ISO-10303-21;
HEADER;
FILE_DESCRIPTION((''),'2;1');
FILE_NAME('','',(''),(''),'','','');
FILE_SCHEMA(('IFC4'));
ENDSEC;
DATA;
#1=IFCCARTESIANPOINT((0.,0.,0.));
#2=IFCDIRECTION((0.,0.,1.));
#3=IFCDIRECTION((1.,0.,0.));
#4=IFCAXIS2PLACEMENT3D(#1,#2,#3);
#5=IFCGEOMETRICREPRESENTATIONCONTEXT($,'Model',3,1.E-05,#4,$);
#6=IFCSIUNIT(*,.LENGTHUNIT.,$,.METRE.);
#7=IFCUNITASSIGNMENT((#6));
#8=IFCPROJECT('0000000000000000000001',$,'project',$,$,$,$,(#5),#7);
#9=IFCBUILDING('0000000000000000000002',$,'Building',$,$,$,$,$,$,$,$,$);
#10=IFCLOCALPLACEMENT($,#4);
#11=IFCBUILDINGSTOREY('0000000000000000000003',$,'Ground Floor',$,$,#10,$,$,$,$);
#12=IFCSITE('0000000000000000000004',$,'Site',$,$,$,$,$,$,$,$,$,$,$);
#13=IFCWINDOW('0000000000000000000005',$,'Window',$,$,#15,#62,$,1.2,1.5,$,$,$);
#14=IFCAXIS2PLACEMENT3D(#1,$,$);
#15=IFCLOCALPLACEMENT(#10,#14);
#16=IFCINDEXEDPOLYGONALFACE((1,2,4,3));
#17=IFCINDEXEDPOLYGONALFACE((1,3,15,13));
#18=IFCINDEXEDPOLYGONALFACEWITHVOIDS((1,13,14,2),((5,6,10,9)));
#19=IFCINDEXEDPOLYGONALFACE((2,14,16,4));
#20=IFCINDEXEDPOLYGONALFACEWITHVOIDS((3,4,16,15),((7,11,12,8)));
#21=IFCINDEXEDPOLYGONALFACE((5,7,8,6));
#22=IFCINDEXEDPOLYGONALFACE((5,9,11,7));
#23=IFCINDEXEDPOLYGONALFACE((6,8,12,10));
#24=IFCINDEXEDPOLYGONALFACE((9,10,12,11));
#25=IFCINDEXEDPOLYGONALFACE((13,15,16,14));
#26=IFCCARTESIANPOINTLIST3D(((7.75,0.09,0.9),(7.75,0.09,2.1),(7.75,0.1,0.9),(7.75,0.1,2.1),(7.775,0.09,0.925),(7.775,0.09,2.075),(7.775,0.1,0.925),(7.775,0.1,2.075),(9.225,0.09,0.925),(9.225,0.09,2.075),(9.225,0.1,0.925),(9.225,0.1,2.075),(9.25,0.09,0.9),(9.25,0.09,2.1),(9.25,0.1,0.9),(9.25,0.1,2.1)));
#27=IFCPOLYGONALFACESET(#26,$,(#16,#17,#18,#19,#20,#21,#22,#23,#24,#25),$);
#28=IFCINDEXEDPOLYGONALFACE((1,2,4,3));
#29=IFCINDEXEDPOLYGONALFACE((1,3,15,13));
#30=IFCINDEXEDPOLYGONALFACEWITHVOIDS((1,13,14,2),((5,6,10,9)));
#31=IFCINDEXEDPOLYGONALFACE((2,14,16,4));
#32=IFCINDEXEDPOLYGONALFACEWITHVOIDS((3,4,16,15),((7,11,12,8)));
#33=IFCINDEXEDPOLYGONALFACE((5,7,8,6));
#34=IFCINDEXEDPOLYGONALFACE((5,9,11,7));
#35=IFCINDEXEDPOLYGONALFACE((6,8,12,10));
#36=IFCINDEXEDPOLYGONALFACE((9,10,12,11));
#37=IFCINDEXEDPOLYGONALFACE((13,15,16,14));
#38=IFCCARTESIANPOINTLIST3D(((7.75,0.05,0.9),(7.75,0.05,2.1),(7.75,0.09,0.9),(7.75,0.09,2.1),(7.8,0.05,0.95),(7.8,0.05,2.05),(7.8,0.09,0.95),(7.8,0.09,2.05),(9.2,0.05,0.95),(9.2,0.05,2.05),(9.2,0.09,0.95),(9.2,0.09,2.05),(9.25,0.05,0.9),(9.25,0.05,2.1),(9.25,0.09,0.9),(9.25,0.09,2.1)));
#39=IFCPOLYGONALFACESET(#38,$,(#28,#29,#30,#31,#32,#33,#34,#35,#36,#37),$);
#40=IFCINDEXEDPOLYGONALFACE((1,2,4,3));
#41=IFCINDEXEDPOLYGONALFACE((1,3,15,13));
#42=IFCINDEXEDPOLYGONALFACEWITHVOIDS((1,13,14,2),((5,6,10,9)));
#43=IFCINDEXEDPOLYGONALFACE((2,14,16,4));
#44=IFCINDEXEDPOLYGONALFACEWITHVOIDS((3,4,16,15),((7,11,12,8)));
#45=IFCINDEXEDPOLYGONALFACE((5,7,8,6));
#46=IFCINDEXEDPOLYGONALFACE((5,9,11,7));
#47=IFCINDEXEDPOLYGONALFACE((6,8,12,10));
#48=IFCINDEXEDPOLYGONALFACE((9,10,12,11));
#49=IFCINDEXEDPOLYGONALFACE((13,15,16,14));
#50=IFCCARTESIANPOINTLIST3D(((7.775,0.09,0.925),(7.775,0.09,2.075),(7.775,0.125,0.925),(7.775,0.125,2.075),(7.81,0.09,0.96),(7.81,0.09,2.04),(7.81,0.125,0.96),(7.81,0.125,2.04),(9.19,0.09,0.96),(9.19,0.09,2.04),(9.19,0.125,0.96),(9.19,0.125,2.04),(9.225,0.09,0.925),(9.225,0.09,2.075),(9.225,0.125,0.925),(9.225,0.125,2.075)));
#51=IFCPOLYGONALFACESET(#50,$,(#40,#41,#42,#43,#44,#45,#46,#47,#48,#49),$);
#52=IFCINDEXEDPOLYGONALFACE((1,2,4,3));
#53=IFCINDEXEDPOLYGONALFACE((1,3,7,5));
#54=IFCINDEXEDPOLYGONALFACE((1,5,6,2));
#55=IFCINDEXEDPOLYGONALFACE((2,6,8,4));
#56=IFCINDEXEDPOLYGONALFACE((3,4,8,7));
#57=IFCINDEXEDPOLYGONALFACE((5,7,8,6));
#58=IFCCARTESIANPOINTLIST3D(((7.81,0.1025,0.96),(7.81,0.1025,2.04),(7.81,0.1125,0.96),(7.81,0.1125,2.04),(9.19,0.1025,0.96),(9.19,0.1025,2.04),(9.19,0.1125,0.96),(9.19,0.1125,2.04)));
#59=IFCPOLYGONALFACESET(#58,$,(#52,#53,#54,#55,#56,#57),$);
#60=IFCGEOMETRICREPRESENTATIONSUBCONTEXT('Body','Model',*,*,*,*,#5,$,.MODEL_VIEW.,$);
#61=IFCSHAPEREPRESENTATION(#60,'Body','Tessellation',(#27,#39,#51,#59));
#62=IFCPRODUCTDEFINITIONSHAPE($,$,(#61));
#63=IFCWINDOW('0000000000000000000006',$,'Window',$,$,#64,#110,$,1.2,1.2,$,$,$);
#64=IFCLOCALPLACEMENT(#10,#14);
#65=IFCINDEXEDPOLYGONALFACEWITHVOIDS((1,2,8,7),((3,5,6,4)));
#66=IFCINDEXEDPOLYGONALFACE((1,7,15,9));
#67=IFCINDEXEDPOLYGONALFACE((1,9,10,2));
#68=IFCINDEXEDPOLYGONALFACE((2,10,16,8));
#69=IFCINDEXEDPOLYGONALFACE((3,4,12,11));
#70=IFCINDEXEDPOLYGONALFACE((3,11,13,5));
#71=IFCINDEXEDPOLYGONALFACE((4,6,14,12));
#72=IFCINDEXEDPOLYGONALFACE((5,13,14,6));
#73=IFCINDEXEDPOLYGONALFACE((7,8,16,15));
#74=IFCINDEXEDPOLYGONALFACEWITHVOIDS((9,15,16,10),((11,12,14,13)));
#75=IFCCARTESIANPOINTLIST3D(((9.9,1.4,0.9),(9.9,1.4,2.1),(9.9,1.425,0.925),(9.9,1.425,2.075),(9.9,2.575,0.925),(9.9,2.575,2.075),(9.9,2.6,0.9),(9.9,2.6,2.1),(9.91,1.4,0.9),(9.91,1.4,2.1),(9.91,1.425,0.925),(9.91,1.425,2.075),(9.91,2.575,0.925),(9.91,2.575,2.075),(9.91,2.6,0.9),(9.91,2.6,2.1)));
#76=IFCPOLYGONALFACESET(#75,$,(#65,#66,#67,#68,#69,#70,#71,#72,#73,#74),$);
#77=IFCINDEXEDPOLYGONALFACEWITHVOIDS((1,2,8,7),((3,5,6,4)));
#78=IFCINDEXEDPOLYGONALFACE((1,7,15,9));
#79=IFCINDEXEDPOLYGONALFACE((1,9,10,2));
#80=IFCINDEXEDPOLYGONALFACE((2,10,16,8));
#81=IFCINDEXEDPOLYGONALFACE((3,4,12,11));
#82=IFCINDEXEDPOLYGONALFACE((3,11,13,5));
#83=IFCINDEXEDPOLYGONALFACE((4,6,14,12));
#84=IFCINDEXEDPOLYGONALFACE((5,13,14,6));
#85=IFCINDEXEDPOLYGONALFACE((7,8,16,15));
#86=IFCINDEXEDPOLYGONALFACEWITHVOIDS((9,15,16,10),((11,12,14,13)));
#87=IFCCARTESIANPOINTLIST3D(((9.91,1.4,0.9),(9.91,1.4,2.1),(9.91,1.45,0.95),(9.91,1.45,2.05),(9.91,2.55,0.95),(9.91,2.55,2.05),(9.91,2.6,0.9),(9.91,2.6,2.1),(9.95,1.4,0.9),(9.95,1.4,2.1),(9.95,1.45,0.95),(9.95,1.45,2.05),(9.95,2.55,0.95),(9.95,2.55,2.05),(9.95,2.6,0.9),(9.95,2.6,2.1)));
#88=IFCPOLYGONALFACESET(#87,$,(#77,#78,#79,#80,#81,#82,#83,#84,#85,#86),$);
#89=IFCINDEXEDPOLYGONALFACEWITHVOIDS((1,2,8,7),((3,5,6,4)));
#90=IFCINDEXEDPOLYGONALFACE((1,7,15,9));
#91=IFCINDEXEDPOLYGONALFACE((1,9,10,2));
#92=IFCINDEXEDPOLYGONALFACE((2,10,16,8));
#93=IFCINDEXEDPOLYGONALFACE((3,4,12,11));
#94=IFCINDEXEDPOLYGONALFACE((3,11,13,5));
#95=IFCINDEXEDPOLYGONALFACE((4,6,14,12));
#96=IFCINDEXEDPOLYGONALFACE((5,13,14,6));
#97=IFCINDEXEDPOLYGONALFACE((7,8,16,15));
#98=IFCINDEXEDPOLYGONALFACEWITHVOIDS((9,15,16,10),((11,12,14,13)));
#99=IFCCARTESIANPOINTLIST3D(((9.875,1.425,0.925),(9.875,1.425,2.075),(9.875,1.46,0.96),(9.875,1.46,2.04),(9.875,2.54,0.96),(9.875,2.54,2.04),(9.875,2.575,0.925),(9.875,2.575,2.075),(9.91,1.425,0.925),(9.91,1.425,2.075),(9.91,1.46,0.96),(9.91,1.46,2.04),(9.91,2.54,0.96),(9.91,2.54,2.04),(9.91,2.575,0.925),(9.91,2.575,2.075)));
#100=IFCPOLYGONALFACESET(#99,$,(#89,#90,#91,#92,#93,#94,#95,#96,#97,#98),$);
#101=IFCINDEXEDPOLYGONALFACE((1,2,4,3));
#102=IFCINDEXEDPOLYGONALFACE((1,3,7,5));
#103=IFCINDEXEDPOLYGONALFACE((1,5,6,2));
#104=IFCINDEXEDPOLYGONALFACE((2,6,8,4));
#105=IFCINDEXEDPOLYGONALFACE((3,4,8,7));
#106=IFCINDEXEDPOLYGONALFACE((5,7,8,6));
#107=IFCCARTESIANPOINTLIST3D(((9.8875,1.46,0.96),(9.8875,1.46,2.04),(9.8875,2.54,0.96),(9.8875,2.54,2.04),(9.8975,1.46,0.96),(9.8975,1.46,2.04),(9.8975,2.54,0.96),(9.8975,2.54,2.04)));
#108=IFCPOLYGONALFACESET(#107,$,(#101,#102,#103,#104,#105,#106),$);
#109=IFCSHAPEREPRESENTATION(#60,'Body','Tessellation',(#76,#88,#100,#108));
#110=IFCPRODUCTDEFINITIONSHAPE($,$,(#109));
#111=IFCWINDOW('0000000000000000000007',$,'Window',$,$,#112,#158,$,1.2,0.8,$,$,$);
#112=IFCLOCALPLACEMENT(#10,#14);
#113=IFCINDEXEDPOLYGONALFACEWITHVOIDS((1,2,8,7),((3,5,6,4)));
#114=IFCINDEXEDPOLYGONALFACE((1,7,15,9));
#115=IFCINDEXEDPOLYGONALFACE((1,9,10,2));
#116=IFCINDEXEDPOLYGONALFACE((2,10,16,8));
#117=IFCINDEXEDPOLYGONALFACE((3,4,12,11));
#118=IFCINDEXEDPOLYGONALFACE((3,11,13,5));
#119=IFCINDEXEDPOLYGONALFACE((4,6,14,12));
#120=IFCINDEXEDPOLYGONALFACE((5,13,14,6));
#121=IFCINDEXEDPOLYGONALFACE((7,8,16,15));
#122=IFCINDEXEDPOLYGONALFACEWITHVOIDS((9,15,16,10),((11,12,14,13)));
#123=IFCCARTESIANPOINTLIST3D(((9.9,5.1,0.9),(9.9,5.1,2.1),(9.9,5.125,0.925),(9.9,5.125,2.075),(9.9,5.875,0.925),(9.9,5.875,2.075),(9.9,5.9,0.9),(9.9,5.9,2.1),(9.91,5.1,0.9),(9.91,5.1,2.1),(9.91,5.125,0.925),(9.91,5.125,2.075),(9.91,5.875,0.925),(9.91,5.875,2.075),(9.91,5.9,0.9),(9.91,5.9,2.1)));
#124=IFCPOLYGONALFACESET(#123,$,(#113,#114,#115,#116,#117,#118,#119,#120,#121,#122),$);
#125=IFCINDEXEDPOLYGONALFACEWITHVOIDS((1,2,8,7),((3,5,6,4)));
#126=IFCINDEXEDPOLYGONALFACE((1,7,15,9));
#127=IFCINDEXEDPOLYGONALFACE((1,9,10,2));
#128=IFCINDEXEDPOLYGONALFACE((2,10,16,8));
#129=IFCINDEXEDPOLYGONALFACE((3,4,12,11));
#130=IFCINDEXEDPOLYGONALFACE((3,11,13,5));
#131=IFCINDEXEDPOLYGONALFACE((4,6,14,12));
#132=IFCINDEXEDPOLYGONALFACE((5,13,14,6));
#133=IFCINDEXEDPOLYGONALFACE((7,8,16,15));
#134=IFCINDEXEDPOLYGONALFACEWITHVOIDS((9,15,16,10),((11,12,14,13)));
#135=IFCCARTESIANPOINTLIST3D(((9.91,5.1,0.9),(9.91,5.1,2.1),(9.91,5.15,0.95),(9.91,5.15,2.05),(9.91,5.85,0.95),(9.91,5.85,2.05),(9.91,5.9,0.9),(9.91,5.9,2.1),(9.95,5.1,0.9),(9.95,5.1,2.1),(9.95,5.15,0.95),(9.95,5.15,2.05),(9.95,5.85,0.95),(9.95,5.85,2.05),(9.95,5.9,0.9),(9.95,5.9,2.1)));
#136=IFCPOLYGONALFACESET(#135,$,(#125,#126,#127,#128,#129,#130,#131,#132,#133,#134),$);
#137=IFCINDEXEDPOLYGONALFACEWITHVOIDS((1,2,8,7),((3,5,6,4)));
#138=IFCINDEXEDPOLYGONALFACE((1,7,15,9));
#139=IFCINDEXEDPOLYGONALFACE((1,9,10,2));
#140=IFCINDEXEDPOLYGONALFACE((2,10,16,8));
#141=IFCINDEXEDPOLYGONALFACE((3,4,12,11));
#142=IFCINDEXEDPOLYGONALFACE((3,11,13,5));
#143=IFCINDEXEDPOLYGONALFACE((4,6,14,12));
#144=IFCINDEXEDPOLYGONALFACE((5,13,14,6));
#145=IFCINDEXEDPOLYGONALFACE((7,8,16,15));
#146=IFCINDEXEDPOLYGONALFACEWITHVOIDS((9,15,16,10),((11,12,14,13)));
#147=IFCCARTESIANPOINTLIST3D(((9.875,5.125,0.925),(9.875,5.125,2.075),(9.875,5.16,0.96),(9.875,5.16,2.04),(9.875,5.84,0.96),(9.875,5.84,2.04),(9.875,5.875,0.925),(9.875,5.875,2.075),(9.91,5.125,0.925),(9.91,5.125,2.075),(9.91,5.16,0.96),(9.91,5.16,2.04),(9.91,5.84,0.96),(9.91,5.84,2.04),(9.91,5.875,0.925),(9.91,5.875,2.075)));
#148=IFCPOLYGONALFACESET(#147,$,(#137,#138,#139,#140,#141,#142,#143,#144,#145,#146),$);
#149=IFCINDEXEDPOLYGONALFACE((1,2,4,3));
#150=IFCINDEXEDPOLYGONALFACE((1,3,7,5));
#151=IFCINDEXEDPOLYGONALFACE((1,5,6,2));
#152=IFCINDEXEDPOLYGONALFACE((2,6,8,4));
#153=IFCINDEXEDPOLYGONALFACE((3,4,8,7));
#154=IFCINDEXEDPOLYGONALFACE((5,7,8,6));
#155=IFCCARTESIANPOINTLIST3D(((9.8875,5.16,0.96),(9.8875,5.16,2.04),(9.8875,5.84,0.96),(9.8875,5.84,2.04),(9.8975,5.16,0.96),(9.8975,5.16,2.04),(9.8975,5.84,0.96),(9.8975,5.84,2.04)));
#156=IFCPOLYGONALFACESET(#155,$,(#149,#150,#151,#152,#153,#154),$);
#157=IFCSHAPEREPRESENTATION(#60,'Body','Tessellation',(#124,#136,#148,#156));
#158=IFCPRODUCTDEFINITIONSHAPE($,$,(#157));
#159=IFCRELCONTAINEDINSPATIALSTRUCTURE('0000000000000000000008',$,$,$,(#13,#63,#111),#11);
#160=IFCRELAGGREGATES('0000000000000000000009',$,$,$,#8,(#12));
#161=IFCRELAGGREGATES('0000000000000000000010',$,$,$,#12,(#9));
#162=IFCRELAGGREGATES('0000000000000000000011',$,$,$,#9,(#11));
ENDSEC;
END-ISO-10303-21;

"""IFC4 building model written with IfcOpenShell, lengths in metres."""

from ifc_helpers import new_model, si_unit, frame, origin_with_axes, place, context, subcontext, project, spatial, line, indexed_curve, outline, extrude, element, save


model = new_model("IFC4")

# Units and contexts
model_context = context("Model", 3, precision=1e-05, world=origin_with_axes())
body_context = subcontext(model_context, "Body", "Model", "MODEL_VIEW")
ifc_project = project(units=[si_unit("LENGTHUNIT", "METRE")], contexts=[model_context])

# Site, building, storey
site = spatial("IfcSite", under=ifc_project, Name="Site")
building = spatial("IfcBuilding", under=site, Name="Building")
storey_placement = place(None, origin_with_axes())
storey = spatial("IfcBuildingStorey", under=building, at=storey_placement, Name="Ground Floor")

# Windows
window_1_placement = place(storey_placement, frame((7.75, 0.0, 0.9), z_axis=(0.0, 0.0, 1.0), x_axis=(1.0, 0.0, 0.0)))
element("IfcWindow", 1, at=window_1_placement, inside=storey, Name="Window", OverallHeight=1.2, OverallWidth=1.5, context=body_context, shape_type="SweptSolid", body=[
    extrude(outline(indexed_curve([(0.0, 0.0), (1.5, 0.0), (1.5, 1.2), (0.0, 1.2)], segments=[line(1, 2, 3, 4, 1)]), holes=[indexed_curve([(0.025, 0.025), (1.475, 0.025), (1.475, 1.175), (0.025, 1.175)], segments=[line(1, 2, 3, 4, 1)])]), frame((0.0, 0.09, 0.0), z_axis=(0.0, -1.0, 0.0), x_axis=(1.0, 0.0, 0.0)), (0.0, 0.0, -1.0), 0.01),
    extrude(outline(indexed_curve([(0.0, 0.0), (1.5, 0.0), (1.5, 1.2), (0.0, 1.2)], segments=[line(1, 2, 3, 4, 1)]), holes=[indexed_curve([(0.05, 0.05), (1.45, 0.05), (1.45, 1.15), (0.05, 1.15)], segments=[line(1, 2, 3, 4, 1)])]), frame((0.0, 0.05, 0.0), z_axis=(0.0, -1.0, 0.0), x_axis=(1.0, 0.0, 0.0)), (0.0, 0.0, -1.0), 0.04),
    extrude(outline(indexed_curve([(0.0, 0.0), (1.45, 0.0), (1.45, 1.15), (0.0, 1.15)], segments=[line(1, 2, 3, 4, 1)]), holes=[indexed_curve([(0.035, 0.035), (1.415, 0.035), (1.415, 1.115), (0.035, 1.115)], segments=[line(1, 2, 3, 4, 1)])]), frame((0.025, 0.09, 0.025), z_axis=(0.0, -1.0, 0.0), x_axis=(1.0, 0.0, 0.0)), (0.0, 0.0, -1.0), 0.035),
    extrude(outline(indexed_curve([(0.035, 0.035), (1.415, 0.035), (1.415, 1.115), (0.035, 1.115)], segments=[line(1, 2, 3, 4, 1)])), frame((0.025, 0.1025, 0.025), z_axis=(0.0, -1.0, 0.0), x_axis=(1.0, 0.0, 0.0)), (0.0, 0.0, -1.0), 0.01),
])
window_2_placement = place(storey_placement, frame((10.0, 1.4, 0.9), z_axis=(0.0, 0.0, 1.0), x_axis=(0.0, 1.0, 0.0)))
element("IfcWindow", 2, at=window_2_placement, inside=storey, Name="Window", OverallHeight=1.2, OverallWidth=1.2, context=body_context, shape_type="SweptSolid", body=[
    extrude(outline(indexed_curve([(0.0, 0.0), (1.2, 0.0), (1.2, 1.2), (0.0, 1.2)], segments=[line(1, 2, 3, 4, 1)]), holes=[indexed_curve([(0.025, 0.025), (1.175, 0.025), (1.175, 1.175), (0.025, 1.175)], segments=[line(1, 2, 3, 4, 1)])]), frame((0.0, 0.09, 0.0), z_axis=(0.0, -1.0, 0.0), x_axis=(1.0, 0.0, 0.0)), (0.0, 0.0, -1.0), 0.01),
    extrude(outline(indexed_curve([(0.0, 0.0), (1.2, 0.0), (1.2, 1.2), (0.0, 1.2)], segments=[line(1, 2, 3, 4, 1)]), holes=[indexed_curve([(0.05, 0.05), (1.15, 0.05), (1.15, 1.15), (0.05, 1.15)], segments=[line(1, 2, 3, 4, 1)])]), frame((0.0, 0.05, 0.0), z_axis=(0.0, -1.0, 0.0), x_axis=(1.0, 0.0, 0.0)), (0.0, 0.0, -1.0), 0.04),
    extrude(outline(indexed_curve([(0.0, 0.0), (1.15, 0.0), (1.15, 1.15), (0.0, 1.15)], segments=[line(1, 2, 3, 4, 1)]), holes=[indexed_curve([(0.035, 0.035), (1.115, 0.035), (1.115, 1.115), (0.035, 1.115)], segments=[line(1, 2, 3, 4, 1)])]), frame((0.025, 0.09, 0.025), z_axis=(0.0, -1.0, 0.0), x_axis=(1.0, 0.0, 0.0)), (0.0, 0.0, -1.0), 0.035),
    extrude(outline(indexed_curve([(0.035, 0.035), (1.115, 0.035), (1.115, 1.115), (0.035, 1.115)], segments=[line(1, 2, 3, 4, 1)])), frame((0.025, 0.1025, 0.025), z_axis=(0.0, -1.0, 0.0), x_axis=(1.0, 0.0, 0.0)), (0.0, 0.0, -1.0), 0.01),
])
window_3_placement = place(storey_placement, frame((10.0, 5.1, 0.9), z_axis=(0.0, 0.0, 1.0), x_axis=(0.0, 1.0, 0.0)))
element("IfcWindow", 3, at=window_3_placement, inside=storey, Name="Window", OverallHeight=1.2, OverallWidth=0.8, context=body_context, shape_type="SweptSolid", body=[
    extrude(outline(indexed_curve([(0.0, 0.0), (0.8, 0.0), (0.8, 1.2), (0.0, 1.2)], segments=[line(1, 2, 3, 4, 1)]), holes=[indexed_curve([(0.025, 0.025), (0.775, 0.025), (0.775, 1.175), (0.025, 1.175)], segments=[line(1, 2, 3, 4, 1)])]), frame((0.0, 0.09, 0.0), z_axis=(0.0, -1.0, 0.0), x_axis=(1.0, 0.0, 0.0)), (0.0, 0.0, -1.0), 0.01),
    extrude(outline(indexed_curve([(0.0, 0.0), (0.8, 0.0), (0.8, 1.2), (0.0, 1.2)], segments=[line(1, 2, 3, 4, 1)]), holes=[indexed_curve([(0.05, 0.05), (0.75, 0.05), (0.75, 1.15), (0.05, 1.15)], segments=[line(1, 2, 3, 4, 1)])]), frame((0.0, 0.05, 0.0), z_axis=(0.0, -1.0, 0.0), x_axis=(1.0, 0.0, 0.0)), (0.0, 0.0, -1.0), 0.04),
    extrude(outline(indexed_curve([(0.0, 0.0), (0.75, 0.0), (0.75, 1.15), (0.0, 1.15)], segments=[line(1, 2, 3, 4, 1)]), holes=[indexed_curve([(0.035, 0.035), (0.715, 0.035), (0.715, 1.115), (0.035, 1.115)], segments=[line(1, 2, 3, 4, 1)])]), frame((0.025, 0.09, 0.025), z_axis=(0.0, -1.0, 0.0), x_axis=(1.0, 0.0, 0.0)), (0.0, 0.0, -1.0), 0.035),
    extrude(outline(indexed_curve([(0.035, 0.035), (0.715, 0.035), (0.715, 1.115), (0.035, 1.115)], segments=[line(1, 2, 3, 4, 1)])), frame((0.025, 0.1025, 0.025), z_axis=(0.0, -1.0, 0.0), x_axis=(1.0, 0.0, 0.0)), (0.0, 0.0, -1.0), 0.01),
])

save(model, "model.ifc")
